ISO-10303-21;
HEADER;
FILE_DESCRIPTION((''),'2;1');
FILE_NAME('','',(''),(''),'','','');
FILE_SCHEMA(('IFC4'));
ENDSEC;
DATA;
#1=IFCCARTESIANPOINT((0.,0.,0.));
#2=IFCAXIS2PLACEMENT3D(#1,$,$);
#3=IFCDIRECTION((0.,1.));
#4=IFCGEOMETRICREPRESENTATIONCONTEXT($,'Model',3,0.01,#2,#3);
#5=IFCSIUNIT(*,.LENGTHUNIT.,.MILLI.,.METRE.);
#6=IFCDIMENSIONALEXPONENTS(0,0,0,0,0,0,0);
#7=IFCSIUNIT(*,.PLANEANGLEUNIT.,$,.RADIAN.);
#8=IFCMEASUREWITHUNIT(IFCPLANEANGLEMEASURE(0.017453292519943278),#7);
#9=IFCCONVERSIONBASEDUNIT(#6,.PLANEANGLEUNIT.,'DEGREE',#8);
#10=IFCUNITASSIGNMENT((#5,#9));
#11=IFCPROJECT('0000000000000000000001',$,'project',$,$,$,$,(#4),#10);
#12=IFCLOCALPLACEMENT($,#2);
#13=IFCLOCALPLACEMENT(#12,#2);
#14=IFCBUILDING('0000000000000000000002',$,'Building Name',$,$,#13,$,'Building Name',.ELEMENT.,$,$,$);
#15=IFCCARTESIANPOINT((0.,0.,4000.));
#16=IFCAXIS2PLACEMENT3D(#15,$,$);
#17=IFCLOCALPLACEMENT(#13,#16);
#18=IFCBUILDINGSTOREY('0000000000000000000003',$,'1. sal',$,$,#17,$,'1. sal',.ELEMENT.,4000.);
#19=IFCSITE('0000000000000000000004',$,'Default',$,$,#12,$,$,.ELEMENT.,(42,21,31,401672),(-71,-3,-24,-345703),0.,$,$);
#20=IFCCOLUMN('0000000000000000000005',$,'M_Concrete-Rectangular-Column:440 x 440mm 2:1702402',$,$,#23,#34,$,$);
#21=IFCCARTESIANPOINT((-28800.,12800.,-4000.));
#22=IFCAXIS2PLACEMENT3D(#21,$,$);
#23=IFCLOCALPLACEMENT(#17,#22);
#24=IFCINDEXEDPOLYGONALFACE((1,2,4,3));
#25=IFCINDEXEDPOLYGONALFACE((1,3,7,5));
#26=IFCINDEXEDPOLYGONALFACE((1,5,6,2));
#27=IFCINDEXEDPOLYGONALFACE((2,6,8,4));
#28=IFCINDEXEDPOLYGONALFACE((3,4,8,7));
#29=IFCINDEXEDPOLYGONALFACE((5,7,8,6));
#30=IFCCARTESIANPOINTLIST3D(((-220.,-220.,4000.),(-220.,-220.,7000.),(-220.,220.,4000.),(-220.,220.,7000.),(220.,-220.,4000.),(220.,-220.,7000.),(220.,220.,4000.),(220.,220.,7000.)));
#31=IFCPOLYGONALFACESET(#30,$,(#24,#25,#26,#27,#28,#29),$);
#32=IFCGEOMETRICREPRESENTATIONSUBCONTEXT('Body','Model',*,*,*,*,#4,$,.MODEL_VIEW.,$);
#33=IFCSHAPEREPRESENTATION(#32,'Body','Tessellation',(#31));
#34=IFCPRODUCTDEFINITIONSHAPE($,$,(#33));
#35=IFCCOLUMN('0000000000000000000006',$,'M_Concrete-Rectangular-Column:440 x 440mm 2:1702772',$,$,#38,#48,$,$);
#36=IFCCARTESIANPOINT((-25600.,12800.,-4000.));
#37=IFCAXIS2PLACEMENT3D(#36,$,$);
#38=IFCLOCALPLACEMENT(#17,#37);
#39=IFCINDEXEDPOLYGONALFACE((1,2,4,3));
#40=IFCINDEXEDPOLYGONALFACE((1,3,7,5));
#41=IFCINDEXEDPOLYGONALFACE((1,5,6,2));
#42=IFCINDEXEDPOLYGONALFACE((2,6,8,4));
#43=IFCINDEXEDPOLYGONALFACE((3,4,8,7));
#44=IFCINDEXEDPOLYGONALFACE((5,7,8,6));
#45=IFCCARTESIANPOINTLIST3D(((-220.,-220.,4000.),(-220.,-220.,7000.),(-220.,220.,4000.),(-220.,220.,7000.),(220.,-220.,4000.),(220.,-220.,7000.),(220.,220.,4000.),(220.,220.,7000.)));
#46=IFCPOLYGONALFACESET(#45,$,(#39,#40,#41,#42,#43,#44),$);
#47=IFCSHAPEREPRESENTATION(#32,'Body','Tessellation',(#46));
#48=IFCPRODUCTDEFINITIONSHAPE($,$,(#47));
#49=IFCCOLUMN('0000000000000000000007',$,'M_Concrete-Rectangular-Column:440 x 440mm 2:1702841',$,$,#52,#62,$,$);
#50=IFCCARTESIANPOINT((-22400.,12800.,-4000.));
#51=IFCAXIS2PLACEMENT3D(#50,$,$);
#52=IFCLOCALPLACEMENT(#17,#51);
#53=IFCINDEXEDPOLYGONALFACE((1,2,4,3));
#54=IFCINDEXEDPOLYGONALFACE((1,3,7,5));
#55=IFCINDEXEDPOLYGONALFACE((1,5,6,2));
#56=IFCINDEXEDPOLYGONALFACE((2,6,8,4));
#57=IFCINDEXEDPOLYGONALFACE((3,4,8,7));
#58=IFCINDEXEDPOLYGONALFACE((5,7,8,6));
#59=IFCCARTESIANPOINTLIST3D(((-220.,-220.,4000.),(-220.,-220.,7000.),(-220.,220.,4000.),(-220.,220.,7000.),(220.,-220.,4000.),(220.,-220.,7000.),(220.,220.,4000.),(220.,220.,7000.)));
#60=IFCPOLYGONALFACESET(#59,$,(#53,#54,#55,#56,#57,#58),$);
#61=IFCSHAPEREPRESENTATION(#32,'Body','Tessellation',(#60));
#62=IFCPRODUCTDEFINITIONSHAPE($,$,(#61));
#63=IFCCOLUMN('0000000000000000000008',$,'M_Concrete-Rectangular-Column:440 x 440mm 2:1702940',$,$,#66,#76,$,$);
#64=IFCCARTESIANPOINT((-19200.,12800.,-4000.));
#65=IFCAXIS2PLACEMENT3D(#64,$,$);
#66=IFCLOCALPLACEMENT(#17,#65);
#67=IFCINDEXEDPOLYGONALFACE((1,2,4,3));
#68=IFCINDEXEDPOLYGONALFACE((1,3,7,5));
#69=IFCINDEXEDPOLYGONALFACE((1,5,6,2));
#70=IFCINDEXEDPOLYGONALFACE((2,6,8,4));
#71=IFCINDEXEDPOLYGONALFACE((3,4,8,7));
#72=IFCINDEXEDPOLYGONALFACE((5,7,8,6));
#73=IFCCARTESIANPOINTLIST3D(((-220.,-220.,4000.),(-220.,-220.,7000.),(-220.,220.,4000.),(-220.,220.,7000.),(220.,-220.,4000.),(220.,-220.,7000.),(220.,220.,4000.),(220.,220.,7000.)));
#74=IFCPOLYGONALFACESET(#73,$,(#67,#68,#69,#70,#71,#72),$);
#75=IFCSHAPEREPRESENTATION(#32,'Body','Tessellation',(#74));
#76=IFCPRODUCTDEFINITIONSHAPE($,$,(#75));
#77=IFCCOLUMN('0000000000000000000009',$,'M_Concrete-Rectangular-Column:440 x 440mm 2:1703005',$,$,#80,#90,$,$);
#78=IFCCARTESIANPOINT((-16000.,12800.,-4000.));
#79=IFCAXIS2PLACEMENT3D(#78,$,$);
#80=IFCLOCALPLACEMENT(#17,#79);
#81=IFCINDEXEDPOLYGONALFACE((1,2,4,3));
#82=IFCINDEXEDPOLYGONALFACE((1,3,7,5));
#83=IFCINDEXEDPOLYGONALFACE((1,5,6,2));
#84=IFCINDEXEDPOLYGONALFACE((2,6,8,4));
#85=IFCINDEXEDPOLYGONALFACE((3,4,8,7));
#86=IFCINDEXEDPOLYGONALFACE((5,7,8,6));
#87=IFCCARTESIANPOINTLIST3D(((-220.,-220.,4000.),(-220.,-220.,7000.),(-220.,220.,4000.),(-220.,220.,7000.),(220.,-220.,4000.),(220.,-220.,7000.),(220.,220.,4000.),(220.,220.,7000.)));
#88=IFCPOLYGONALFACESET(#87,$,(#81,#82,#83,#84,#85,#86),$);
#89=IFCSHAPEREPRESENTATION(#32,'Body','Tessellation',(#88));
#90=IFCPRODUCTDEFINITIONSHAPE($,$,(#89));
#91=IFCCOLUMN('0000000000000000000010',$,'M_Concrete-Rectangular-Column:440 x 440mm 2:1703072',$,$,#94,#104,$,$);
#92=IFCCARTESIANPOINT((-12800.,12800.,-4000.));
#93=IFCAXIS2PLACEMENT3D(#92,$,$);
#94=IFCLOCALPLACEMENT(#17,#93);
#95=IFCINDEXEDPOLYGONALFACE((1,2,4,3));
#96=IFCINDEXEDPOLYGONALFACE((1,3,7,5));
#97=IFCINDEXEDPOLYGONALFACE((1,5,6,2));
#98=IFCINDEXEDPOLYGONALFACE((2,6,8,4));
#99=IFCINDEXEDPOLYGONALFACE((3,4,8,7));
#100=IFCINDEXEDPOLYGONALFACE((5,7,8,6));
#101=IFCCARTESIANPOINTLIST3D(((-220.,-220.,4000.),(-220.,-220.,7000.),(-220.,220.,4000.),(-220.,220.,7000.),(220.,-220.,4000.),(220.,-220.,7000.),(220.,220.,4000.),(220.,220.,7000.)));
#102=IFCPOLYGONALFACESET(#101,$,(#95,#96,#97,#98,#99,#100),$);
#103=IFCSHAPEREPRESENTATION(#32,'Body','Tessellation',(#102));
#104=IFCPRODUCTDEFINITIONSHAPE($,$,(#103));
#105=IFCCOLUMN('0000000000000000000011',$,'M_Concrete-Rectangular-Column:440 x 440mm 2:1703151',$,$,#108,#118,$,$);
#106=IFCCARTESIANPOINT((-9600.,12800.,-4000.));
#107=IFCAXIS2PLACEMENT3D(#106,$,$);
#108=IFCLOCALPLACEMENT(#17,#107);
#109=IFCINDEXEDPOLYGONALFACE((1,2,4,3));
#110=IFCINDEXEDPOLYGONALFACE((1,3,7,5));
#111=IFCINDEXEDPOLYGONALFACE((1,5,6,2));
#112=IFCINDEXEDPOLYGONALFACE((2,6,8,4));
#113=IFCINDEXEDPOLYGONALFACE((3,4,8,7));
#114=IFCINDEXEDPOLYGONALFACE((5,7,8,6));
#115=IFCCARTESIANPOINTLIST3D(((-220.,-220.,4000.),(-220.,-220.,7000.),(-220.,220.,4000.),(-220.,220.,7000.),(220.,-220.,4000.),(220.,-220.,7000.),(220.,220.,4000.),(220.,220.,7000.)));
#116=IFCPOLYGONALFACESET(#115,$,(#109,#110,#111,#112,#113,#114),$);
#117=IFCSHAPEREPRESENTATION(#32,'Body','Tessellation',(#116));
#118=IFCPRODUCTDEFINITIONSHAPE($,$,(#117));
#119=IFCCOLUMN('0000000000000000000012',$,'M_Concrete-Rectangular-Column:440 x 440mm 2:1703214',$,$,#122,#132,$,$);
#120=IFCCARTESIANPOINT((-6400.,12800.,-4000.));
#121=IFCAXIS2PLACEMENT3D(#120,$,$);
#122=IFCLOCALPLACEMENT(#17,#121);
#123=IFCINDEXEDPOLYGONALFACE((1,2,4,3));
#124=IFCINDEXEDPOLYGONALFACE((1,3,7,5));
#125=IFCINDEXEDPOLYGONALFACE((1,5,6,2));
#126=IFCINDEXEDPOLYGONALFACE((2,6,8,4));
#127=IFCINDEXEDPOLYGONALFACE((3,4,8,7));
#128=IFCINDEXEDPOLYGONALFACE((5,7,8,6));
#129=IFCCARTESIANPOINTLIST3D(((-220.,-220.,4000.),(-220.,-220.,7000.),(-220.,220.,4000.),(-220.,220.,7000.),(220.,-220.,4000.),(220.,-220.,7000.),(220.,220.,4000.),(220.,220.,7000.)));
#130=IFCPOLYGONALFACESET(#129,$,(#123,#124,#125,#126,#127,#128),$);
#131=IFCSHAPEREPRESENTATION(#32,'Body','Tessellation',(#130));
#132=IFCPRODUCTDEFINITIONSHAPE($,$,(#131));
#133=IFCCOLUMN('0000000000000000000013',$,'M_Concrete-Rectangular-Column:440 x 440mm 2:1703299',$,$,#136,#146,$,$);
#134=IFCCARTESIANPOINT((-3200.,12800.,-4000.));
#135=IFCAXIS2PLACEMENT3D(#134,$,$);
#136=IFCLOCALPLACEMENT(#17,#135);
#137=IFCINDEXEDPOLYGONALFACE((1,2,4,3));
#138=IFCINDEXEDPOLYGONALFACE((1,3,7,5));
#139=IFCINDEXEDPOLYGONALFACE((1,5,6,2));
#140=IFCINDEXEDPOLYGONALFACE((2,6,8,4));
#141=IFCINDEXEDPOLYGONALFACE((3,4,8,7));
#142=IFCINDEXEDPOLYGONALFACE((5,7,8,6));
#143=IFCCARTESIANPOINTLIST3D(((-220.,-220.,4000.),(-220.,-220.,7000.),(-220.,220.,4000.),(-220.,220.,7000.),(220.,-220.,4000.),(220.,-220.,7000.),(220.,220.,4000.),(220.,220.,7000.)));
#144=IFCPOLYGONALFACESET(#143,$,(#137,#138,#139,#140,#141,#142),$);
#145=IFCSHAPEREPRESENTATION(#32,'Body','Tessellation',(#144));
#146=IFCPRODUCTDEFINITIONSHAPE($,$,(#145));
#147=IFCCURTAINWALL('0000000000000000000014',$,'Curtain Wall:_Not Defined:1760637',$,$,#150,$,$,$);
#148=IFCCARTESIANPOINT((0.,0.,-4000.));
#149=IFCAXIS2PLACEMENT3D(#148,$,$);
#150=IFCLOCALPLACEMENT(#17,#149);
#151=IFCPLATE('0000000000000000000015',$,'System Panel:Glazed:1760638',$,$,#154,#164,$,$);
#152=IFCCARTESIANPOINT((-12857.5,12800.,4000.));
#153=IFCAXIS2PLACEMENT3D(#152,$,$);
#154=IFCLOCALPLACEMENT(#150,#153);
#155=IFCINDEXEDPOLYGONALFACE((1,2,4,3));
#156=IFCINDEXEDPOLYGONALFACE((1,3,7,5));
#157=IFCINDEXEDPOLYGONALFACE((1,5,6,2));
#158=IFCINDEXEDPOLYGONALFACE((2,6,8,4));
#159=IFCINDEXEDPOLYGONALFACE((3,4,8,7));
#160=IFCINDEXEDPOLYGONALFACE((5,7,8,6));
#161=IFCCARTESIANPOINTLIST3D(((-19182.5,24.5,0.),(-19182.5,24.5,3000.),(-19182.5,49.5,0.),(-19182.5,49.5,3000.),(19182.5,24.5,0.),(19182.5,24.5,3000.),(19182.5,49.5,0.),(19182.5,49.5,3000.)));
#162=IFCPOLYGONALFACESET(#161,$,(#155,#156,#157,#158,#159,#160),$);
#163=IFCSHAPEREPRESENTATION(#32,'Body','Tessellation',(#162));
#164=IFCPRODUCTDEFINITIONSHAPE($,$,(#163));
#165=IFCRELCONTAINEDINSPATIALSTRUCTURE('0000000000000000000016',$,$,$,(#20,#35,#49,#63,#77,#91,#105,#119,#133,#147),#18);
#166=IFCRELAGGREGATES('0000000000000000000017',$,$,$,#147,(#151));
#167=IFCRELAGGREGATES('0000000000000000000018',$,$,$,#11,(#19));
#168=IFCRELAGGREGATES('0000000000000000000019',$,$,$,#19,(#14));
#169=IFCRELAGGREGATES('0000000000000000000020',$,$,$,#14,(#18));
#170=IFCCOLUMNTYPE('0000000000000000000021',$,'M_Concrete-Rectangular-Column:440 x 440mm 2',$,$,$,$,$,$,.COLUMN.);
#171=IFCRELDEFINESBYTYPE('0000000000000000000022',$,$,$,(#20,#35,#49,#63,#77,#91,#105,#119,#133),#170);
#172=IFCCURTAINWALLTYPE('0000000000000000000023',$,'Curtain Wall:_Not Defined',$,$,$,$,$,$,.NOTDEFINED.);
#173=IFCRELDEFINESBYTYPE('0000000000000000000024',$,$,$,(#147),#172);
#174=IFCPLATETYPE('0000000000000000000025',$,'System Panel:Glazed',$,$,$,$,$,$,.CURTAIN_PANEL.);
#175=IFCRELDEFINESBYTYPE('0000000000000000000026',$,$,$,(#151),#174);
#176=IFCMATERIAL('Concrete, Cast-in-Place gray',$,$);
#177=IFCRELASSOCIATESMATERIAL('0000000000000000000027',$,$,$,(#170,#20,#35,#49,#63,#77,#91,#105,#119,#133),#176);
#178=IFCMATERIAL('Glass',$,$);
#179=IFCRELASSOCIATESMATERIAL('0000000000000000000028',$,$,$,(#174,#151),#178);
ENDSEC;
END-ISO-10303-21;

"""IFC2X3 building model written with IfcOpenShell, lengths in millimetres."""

from ifc_helpers import new_model, entity, si_unit, converted_unit, direction, frame, origin, origin_2d_with_axis, place, context, subcontext, project, spatial, rectangle, extrude, source, transform, mapped, material, type_object, type_shapes, element, aggregate, save


model = new_model("IFC2X3")

# Units and contexts
model_context = context("Model", 3, precision=0.01, world=origin(), true_north=direction((0.0, 1.0)))
body_context = subcontext(model_context, "Body", "Model", "MODEL_VIEW")
ifc_project = project(units=[si_unit("LENGTHUNIT", "METRE", prefix="MILLI"), converted_unit("PLANEANGLEUNIT", "DEGREE", entity("IfcPlaneAngleMeasure", 0.017453292519943278), si_unit("PLANEANGLEUNIT", "RADIAN"), dimensions=[0, 0, 0, 0, 0, 0, 0])], contexts=[model_context])

# Site, building, storey
site_placement = place(None, origin())
site = spatial("IfcSite", under=ifc_project, at=site_placement, Name="Default", CompositionType="ELEMENT", RefLatitude=(42, 21, 31, 401672), RefLongitude=(-71, -3, -24, -345703), RefElevation=0.0)
building_placement = place(site_placement, origin())
building = spatial("IfcBuilding", under=site, at=building_placement, Name="Building Name", LongName="Building Name", CompositionType="ELEMENT")
storey_placement = place(building_placement, frame((0.0, 0.0, 4000.0)))
storey = spatial("IfcBuildingStorey", under=building, at=storey_placement, Name="1. sal", LongName="1. sal", CompositionType="ELEMENT", Elevation=4000.0)

# Columns
ifc_material_1 = material(Name="Concrete, Cast-in-Place gray")
column_type = type_object("IfcColumnType", Name="M_Concrete-Rectangular-Column:440 x 440mm 2", PredefinedType="COLUMN", material=ifc_material_1)
shared_shape_1 = source(origin(), body_context, "Body", "SweptSolid", [
    extrude(rectangle(XDim=440.0, YDim=440.0, at=origin_2d_with_axis()), frame((0.0, 0.0, 4000.0), z_axis=(0.0, 0.0, 1.0), x_axis=(-1.0, 0.0, 0.0)), (0.0, 0.0, 1.0), 3000.0),
])
type_shapes(column_type, [shared_shape_1])
for number, where, name in (
    (1, (-28800.0, 12800.0, -4000.0), "M_Concrete-Rectangular-Column:440 x 440mm 2:1702402"),
    (2, (-25600.0, 12800.0, -4000.0), "M_Concrete-Rectangular-Column:440 x 440mm 2:1702772"),
    (3, (-22400.0, 12800.0, -4000.0), "M_Concrete-Rectangular-Column:440 x 440mm 2:1702841"),
    (4, (-19200.0, 12800.0, -4000.0), "M_Concrete-Rectangular-Column:440 x 440mm 2:1702940"),
    (5, (-16000.0, 12800.0, -4000.0), "M_Concrete-Rectangular-Column:440 x 440mm 2:1703005"),
    (6, (-12800.0, 12800.0, -4000.0), "M_Concrete-Rectangular-Column:440 x 440mm 2:1703072"),
    (7, (-9600.0, 12800.0, -4000.0), "M_Concrete-Rectangular-Column:440 x 440mm 2:1703151"),
    (8, (-6400.0, 12800.0, -4000.0), "M_Concrete-Rectangular-Column:440 x 440mm 2:1703214"),
    (9, (-3200.0, 12800.0, -4000.0), "M_Concrete-Rectangular-Column:440 x 440mm 2:1703299"),
):
    element("IfcColumn", number, at=place(storey_placement, frame(where)), inside=storey, type_object=column_type, material=ifc_material_1, Name=name, context=body_context, shape_type="MappedRepresentation", body=[
        mapped(shared_shape_1, transform((0.0, 0.0, 0.0), scale=1.0)),
    ])

# Curtain wall, plate
curtain_wall_type = type_object("IfcCurtainWallType", Name="Curtain Wall:_Not Defined", PredefinedType="NOTDEFINED")
curtain_wall_placement = place(storey_placement, frame((0.0, 0.0, -4000.0)))
curtain_wall = element("IfcCurtainWall", 10, at=curtain_wall_placement, inside=storey, type_object=curtain_wall_type, Name="Curtain Wall:_Not Defined:1760637")
ifc_material_2 = material(Name="Glass")
plate_type = type_object("IfcPlateType", Name="System Panel:Glazed", PredefinedType="CURTAIN_PANEL", material=ifc_material_2)
shared_shape_2 = source(origin(), body_context, "Body", "SweptSolid", [
    extrude(rectangle(XDim=25.0, YDim=38365.0, at=origin_2d_with_axis()), frame((0.0, 37.0, 0.0), z_axis=(0.0, 0.0, 1.0), x_axis=(0.0, 1.0, 0.0)), (0.0, 0.0, 1.0), 3000.0),
])
type_shapes(plate_type, [shared_shape_2])
plate_placement = place(curtain_wall_placement, frame((-12857.5, 12800.0, 4000.0)))
plate = element("IfcPlate", 11, at=plate_placement, type_object=plate_type, material=ifc_material_2, Name="System Panel:Glazed:1760638", context=body_context, shape_type="MappedRepresentation", body=[
    mapped(shared_shape_2, transform((0.0, 0.0, 0.0), scale=1.0)),
])
aggregate(curtain_wall, [plate])

save(model, "model.ifc")
